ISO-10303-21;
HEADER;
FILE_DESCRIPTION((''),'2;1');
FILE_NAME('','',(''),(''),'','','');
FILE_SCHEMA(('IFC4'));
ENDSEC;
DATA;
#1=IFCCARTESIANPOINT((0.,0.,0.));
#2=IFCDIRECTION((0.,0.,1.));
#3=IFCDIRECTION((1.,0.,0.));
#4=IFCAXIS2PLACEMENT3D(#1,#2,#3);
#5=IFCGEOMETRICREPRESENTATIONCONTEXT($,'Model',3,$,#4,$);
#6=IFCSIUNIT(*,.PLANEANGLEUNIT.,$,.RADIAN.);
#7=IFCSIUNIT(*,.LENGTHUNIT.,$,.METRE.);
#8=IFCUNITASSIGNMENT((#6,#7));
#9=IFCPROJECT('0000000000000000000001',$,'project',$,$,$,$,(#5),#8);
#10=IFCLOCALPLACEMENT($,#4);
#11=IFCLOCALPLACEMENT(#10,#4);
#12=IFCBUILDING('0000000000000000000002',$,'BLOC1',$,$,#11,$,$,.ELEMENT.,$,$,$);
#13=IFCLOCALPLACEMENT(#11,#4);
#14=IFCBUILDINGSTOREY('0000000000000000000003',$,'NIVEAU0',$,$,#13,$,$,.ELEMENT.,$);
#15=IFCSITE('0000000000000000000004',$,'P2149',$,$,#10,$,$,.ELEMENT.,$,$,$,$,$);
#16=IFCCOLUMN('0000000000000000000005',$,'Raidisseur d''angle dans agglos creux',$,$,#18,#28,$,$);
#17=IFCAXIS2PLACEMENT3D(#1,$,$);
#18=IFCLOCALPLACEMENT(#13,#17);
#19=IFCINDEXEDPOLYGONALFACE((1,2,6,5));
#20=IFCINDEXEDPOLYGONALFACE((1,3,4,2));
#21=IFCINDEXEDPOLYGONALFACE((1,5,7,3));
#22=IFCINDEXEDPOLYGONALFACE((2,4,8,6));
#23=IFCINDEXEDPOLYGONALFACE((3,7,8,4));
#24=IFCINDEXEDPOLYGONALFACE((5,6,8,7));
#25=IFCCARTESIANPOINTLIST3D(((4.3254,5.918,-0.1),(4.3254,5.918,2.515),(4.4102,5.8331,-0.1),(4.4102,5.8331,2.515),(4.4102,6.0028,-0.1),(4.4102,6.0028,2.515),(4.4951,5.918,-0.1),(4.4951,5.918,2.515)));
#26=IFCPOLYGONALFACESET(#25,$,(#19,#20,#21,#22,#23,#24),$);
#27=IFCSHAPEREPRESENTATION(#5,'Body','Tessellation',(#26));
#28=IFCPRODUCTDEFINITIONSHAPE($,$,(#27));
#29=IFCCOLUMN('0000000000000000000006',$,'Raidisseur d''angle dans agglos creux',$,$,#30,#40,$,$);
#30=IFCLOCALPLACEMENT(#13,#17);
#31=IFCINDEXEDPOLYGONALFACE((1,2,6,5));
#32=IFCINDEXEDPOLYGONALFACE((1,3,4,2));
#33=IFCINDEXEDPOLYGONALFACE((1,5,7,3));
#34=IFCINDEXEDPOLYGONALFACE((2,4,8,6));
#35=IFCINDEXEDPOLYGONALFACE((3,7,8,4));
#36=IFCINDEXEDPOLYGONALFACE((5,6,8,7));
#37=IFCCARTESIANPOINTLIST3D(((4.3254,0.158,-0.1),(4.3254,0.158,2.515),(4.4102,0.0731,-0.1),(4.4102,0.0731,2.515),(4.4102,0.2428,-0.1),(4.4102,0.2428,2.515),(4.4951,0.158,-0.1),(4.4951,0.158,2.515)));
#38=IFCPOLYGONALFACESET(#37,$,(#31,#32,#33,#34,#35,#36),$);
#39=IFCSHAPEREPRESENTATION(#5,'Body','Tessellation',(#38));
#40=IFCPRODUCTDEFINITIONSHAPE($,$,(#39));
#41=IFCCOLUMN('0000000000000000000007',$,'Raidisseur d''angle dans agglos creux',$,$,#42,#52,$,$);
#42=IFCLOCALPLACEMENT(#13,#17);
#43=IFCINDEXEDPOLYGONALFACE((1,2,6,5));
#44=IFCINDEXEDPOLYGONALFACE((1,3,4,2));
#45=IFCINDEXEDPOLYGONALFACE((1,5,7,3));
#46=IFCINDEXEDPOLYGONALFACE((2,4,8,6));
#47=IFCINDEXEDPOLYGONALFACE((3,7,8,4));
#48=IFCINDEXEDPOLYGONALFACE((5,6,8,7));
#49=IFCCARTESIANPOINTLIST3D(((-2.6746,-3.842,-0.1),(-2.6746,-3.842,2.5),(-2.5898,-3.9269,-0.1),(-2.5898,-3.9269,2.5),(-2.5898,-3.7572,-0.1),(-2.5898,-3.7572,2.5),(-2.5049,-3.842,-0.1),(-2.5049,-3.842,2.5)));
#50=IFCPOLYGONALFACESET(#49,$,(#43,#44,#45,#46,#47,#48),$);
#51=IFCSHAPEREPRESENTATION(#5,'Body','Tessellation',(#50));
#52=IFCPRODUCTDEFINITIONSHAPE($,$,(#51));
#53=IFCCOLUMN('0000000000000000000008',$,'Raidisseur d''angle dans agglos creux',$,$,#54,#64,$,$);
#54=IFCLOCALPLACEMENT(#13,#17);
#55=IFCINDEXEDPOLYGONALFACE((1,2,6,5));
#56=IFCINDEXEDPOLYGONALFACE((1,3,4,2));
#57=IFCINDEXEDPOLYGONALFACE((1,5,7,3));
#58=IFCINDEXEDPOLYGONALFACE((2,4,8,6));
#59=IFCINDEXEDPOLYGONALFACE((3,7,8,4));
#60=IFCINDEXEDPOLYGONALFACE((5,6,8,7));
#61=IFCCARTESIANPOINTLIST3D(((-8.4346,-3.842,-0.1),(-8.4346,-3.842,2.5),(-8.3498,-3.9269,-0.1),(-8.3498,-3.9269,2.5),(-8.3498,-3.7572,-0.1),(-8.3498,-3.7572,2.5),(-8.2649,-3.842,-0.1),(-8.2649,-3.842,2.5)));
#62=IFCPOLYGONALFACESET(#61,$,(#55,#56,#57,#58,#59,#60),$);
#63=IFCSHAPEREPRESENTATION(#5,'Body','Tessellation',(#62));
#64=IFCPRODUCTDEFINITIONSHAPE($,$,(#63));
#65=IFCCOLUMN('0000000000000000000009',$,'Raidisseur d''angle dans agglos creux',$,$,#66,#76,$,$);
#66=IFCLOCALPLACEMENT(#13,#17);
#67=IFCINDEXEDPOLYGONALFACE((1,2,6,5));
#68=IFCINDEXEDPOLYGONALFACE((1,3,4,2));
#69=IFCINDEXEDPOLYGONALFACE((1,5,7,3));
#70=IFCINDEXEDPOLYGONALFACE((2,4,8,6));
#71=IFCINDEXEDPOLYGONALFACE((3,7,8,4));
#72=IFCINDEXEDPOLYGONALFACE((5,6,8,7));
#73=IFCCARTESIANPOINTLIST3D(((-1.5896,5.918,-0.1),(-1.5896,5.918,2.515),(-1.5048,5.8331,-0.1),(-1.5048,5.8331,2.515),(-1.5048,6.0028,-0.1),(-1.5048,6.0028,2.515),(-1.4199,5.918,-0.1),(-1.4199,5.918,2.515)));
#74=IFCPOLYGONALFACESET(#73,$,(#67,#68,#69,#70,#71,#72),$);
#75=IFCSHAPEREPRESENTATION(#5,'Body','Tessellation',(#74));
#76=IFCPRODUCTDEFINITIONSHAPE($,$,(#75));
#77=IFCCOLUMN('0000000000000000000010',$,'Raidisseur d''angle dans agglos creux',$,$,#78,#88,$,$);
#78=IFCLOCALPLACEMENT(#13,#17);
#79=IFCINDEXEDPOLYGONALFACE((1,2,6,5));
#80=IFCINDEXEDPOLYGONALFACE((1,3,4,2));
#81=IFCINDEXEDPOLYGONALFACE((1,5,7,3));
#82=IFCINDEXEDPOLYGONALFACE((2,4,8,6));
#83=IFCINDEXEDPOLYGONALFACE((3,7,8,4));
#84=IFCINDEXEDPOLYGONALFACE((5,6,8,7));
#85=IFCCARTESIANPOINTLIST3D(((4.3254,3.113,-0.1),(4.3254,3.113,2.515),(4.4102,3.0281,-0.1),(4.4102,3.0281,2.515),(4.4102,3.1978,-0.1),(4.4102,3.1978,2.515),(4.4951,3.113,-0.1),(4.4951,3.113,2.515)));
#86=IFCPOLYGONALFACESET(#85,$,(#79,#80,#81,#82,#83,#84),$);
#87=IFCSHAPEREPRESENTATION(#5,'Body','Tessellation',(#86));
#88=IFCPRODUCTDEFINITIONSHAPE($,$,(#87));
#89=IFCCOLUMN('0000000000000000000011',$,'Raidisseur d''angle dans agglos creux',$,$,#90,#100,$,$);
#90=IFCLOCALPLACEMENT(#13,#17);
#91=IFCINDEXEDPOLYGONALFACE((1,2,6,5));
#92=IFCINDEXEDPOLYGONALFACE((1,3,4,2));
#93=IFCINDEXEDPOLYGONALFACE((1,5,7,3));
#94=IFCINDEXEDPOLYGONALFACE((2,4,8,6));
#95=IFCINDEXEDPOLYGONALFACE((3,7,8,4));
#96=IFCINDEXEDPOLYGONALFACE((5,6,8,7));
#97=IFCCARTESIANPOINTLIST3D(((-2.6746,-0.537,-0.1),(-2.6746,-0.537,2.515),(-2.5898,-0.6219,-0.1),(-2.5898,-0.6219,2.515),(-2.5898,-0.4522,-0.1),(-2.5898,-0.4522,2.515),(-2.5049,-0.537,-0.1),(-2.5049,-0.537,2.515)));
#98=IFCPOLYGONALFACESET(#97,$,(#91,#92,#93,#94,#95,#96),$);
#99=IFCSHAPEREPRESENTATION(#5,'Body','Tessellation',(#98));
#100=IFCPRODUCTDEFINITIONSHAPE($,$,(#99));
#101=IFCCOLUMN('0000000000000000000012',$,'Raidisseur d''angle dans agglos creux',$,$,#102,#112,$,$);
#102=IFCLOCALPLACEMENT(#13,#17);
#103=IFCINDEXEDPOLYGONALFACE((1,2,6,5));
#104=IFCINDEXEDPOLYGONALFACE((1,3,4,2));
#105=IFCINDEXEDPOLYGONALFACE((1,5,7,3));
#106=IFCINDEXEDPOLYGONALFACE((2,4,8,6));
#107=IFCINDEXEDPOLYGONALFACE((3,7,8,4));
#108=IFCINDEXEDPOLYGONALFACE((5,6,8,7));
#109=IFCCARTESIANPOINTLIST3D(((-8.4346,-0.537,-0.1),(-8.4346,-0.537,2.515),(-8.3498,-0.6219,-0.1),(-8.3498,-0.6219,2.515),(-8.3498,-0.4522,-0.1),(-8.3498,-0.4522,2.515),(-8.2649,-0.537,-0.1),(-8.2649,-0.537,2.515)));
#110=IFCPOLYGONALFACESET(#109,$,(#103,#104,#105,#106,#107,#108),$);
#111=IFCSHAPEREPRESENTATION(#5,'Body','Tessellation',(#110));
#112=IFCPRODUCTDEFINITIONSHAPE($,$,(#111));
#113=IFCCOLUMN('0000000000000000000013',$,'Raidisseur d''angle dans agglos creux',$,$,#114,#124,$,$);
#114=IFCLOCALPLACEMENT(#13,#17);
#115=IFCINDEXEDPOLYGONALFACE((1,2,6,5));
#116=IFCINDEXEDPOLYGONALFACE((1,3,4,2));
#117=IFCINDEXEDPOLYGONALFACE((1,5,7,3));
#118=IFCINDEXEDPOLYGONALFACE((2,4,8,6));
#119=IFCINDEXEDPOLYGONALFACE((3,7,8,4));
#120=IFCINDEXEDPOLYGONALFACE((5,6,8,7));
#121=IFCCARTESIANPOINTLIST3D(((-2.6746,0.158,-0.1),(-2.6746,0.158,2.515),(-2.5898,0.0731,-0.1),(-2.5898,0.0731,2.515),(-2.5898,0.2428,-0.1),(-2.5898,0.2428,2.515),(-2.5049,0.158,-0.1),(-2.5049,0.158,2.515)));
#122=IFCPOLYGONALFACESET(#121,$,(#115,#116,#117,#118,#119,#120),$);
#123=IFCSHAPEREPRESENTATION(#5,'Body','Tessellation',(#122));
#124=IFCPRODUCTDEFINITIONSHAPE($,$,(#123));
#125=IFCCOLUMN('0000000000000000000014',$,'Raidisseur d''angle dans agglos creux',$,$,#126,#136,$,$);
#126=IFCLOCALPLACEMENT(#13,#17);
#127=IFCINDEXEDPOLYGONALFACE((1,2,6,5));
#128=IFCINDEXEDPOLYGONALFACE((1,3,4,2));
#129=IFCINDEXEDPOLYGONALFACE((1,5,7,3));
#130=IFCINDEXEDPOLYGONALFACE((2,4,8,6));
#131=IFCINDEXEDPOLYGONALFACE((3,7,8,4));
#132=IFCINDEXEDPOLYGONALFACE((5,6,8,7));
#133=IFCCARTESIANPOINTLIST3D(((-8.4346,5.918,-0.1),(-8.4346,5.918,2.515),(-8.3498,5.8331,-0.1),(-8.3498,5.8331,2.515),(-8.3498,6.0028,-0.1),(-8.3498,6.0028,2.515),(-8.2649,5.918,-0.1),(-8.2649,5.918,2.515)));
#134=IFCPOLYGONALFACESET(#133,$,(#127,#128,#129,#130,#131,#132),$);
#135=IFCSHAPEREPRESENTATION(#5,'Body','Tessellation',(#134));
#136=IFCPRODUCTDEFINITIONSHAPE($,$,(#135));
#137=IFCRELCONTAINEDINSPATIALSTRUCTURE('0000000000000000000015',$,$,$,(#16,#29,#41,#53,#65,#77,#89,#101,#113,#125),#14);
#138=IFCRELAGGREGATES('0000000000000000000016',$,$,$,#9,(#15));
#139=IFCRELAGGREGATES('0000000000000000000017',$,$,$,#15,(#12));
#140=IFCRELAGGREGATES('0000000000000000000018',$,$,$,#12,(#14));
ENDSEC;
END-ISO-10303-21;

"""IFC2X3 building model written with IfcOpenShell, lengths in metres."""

from ifc_helpers import new_model, si_unit, point, frame, origin_with_axes, place, context, project, spatial, line_curve, trimmed, segment, composite_curve, outline, extrude, element, save


model = new_model("IFC2X3")

# Units and contexts
model_context = context("Model", 3, world=origin_with_axes())
ifc_project = project(units=[si_unit("PLANEANGLEUNIT", "RADIAN"), si_unit("LENGTHUNIT", "METRE")], contexts=[model_context])

# Site, building, storey
site_placement = place(None, origin_with_axes())
site = spatial("IfcSite", under=ifc_project, at=site_placement, Name="P2149", CompositionType="ELEMENT")
building_placement = place(site_placement, origin_with_axes())
building = spatial("IfcBuilding", under=site, at=building_placement, Name="BLOC1", CompositionType="ELEMENT")
storey_placement = place(building_placement, origin_with_axes())
storey = spatial("IfcBuildingStorey", under=building, at=storey_placement, Name="NIVEAU0", CompositionType="ELEMENT")

# Columns
column_1_placement = place(storey_placement, origin_with_axes())
element("IfcColumn", 1, at=column_1_placement, inside=storey, Name="Raidisseur d'angle dans agglos creux", context=model_context, shape_type="SweptSolid", body=[
    extrude(outline(composite_curve([segment(trimmed(line_curve((0.0, 0.0), (1.0, 0.0), 0.12), [point((0.0, 0.0))], [point((0.12, 0.0))], True, "CARTESIAN"), True, "CONTINUOUS"), segment(trimmed(line_curve((0.12, 0.0), (0.0, 1.0), 0.12), [point((0.12, 0.0))], [point((0.12, 0.12))], True, "CARTESIAN"), True, "CONTINUOUS"), segment(trimmed(line_curve((0.12, 0.12), (-1.0, 0.0), 0.12), [point((0.12, 0.12))], [point((0.0, 0.12))], True, "CARTESIAN"), True, "CONTINUOUS"), segment(trimmed(line_curve((0.0, 0.12), (0.0, -1.0), 0.12), [point((0.0, 0.12))], [point((0.0, 0.0))], True, "CARTESIAN"), True, "CONTINUOUS")], self_intersect=False)), frame((4.3254, 5.918, -0.1), z_axis=(0.0, 0.0, -1.0), x_axis=(0.707107, 0.707107, 0.0)), (0.0, 0.0, -1.0), 2.615),
])
column_2_placement = place(storey_placement, origin_with_axes())
element("IfcColumn", 2, at=column_2_placement, inside=storey, Name="Raidisseur d'angle dans agglos creux", context=model_context, shape_type="SweptSolid", body=[
    extrude(outline(composite_curve([segment(trimmed(line_curve((0.0, 0.0), (1.0, 0.0), 0.12), [point((0.0, 0.0))], [point((0.12, 0.0))], True, "CARTESIAN"), True, "CONTINUOUS"), segment(trimmed(line_curve((0.12, 0.0), (0.0, 1.0), 0.12), [point((0.12, 0.0))], [point((0.12, 0.12))], True, "CARTESIAN"), True, "CONTINUOUS"), segment(trimmed(line_curve((0.12, 0.12), (-1.0, 0.0), 0.12), [point((0.12, 0.12))], [point((0.0, 0.12))], True, "CARTESIAN"), True, "CONTINUOUS"), segment(trimmed(line_curve((0.0, 0.12), (0.0, -1.0), 0.12), [point((0.0, 0.12))], [point((0.0, 0.0))], True, "CARTESIAN"), True, "CONTINUOUS")], self_intersect=False)), frame((4.4102, 0.2428, -0.1), z_axis=(0.0, 0.0, -1.0), x_axis=(0.707107, -0.707107, 0.0)), (0.0, 0.0, -1.0), 2.615),
])
column_3_placement = place(storey_placement, origin_with_axes())
element("IfcColumn", 3, at=column_3_placement, inside=storey, Name="Raidisseur d'angle dans agglos creux", context=model_context, shape_type="SweptSolid", body=[
    extrude(outline(composite_curve([segment(trimmed(line_curve((0.0, 0.0), (1.0, 0.0), 0.12), [point((0.0, 0.0))], [point((0.12, 0.0))], True, "CARTESIAN"), True, "CONTINUOUS"), segment(trimmed(line_curve((0.12, 0.0), (0.0, 1.0), 0.12), [point((0.12, 0.0))], [point((0.12, 0.12))], True, "CARTESIAN"), True, "CONTINUOUS"), segment(trimmed(line_curve((0.12, 0.12), (-1.0, 0.0), 0.12), [point((0.12, 0.12))], [point((0.0, 0.12))], True, "CARTESIAN"), True, "CONTINUOUS"), segment(trimmed(line_curve((0.0, 0.12), (0.0, -1.0), 0.12), [point((0.0, 0.12))], [point((0.0, 0.0))], True, "CARTESIAN"), True, "CONTINUOUS")], self_intersect=False)), frame((-2.5049, -3.842, -0.1), z_axis=(0.0, 0.0, -1.0), x_axis=(-0.707107, -0.707107, 0.0)), (0.0, 0.0, -1.0), 2.6),
])
column_4_placement = place(storey_placement, origin_with_axes())
element("IfcColumn", 4, at=column_4_placement, inside=storey, Name="Raidisseur d'angle dans agglos creux", context=model_context, shape_type="SweptSolid", body=[
    extrude(outline(composite_curve([segment(trimmed(line_curve((0.0, 0.0), (1.0, 0.0), 0.12), [point((0.0, 0.0))], [point((0.12, 0.0))], True, "CARTESIAN"), True, "CONTINUOUS"), segment(trimmed(line_curve((0.12, 0.0), (0.0, 1.0), 0.12), [point((0.12, 0.0))], [point((0.12, 0.12))], True, "CARTESIAN"), True, "CONTINUOUS"), segment(trimmed(line_curve((0.12, 0.12), (-1.0, 0.0), 0.12), [point((0.12, 0.12))], [point((0.0, 0.12))], True, "CARTESIAN"), True, "CONTINUOUS"), segment(trimmed(line_curve((0.0, 0.12), (0.0, -1.0), 0.12), [point((0.0, 0.12))], [point((0.0, 0.0))], True, "CARTESIAN"), True, "CONTINUOUS")], self_intersect=False)), frame((-8.2649, -3.842, -0.1), z_axis=(0.0, 0.0, -1.0), x_axis=(-0.707107, -0.707107, 0.0)), (0.0, 0.0, -1.0), 2.6),
])
column_5_placement = place(storey_placement, origin_with_axes())
element("IfcColumn", 5, at=column_5_placement, inside=storey, Name="Raidisseur d'angle dans agglos creux", context=model_context, shape_type="SweptSolid", body=[
    extrude(outline(composite_curve([segment(trimmed(line_curve((0.0, 0.0), (1.0, 0.0), 0.12), [point((0.0, 0.0))], [point((0.12, 0.0))], True, "CARTESIAN"), True, "CONTINUOUS"), segment(trimmed(line_curve((0.12, 0.0), (0.0, 1.0), 0.12), [point((0.12, 0.0))], [point((0.12, 0.12))], True, "CARTESIAN"), True, "CONTINUOUS"), segment(trimmed(line_curve((0.12, 0.12), (-1.0, 0.0), 0.12), [point((0.12, 0.12))], [point((0.0, 0.12))], True, "CARTESIAN"), True, "CONTINUOUS"), segment(trimmed(line_curve((0.0, 0.12), (0.0, -1.0), 0.12), [point((0.0, 0.12))], [point((0.0, 0.0))], True, "CARTESIAN"), True, "CONTINUOUS")], self_intersect=False)), frame((-1.5896, 5.918, -0.1), z_axis=(0.0, 0.0, -1.0), x_axis=(0.707107, 0.707107, 0.0)), (0.0, 0.0, -1.0), 2.615),
])
column_6_placement = place(storey_placement, origin_with_axes())
element("IfcColumn", 6, at=column_6_placement, inside=storey, Name="Raidisseur d'angle dans agglos creux", context=model_context, shape_type="SweptSolid", body=[
    extrude(outline(composite_curve([segment(trimmed(line_curve((0.0, 0.0), (1.0, 0.0), 0.12), [point((0.0, 0.0))], [point((0.12, 0.0))], True, "CARTESIAN"), True, "CONTINUOUS"), segment(trimmed(line_curve((0.12, 0.0), (0.0, 1.0), 0.12), [point((0.12, 0.0))], [point((0.12, 0.12))], True, "CARTESIAN"), True, "CONTINUOUS"), segment(trimmed(line_curve((0.12, 0.12), (-1.0, 0.0), 0.12), [point((0.12, 0.12))], [point((0.0, 0.12))], True, "CARTESIAN"), True, "CONTINUOUS"), segment(trimmed(line_curve((0.0, 0.12), (0.0, -1.0), 0.12), [point((0.0, 0.12))], [point((0.0, 0.0))], True, "CARTESIAN"), True, "CONTINUOUS")], self_intersect=False)), frame((4.4102, 3.1978, -0.1), z_axis=(0.0, 0.0, -1.0), x_axis=(0.707107, -0.707107, 0.0)), (0.0, 0.0, -1.0), 2.615),
])
column_7_placement = place(storey_placement, origin_with_axes())
element("IfcColumn", 7, at=column_7_placement, inside=storey, Name="Raidisseur d'angle dans agglos creux", context=model_context, shape_type="SweptSolid", body=[
    extrude(outline(composite_curve([segment(trimmed(line_curve((0.0, 0.0), (1.0, 0.0), 0.12), [point((0.0, 0.0))], [point((0.12, 0.0))], True, "CARTESIAN"), True, "CONTINUOUS"), segment(trimmed(line_curve((0.12, 0.0), (0.0, 1.0), 0.12), [point((0.12, 0.0))], [point((0.12, 0.12))], True, "CARTESIAN"), True, "CONTINUOUS"), segment(trimmed(line_curve((0.12, 0.12), (-1.0, 0.0), 0.12), [point((0.12, 0.12))], [point((0.0, 0.12))], True, "CARTESIAN"), True, "CONTINUOUS"), segment(trimmed(line_curve((0.0, 0.12), (0.0, -1.0), 0.12), [point((0.0, 0.12))], [point((0.0, 0.0))], True, "CARTESIAN"), True, "CONTINUOUS")], self_intersect=False)), frame((-2.5898, -0.4522, -0.1), z_axis=(0.0, 0.0, -1.0), x_axis=(0.707107, -0.707107, 0.0)), (0.0, 0.0, -1.0), 2.615),
])
column_8_placement = place(storey_placement, origin_with_axes())
element("IfcColumn", 8, at=column_8_placement, inside=storey, Name="Raidisseur d'angle dans agglos creux", context=model_context, shape_type="SweptSolid", body=[
    extrude(outline(composite_curve([segment(trimmed(line_curve((0.0, 0.0), (1.0, 0.0), 0.12), [point((0.0, 0.0))], [point((0.12, 0.0))], True, "CARTESIAN"), True, "CONTINUOUS"), segment(trimmed(line_curve((0.12, 0.0), (0.0, 1.0), 0.12), [point((0.12, 0.0))], [point((0.12, 0.12))], True, "CARTESIAN"), True, "CONTINUOUS"), segment(trimmed(line_curve((0.12, 0.12), (-1.0, 0.0), 0.12), [point((0.12, 0.12))], [point((0.0, 0.12))], True, "CARTESIAN"), True, "CONTINUOUS"), segment(trimmed(line_curve((0.0, 0.12), (0.0, -1.0), 0.12), [point((0.0, 0.12))], [point((0.0, 0.0))], True, "CARTESIAN"), True, "CONTINUOUS")], self_intersect=False)), frame((-8.3498, -0.6219, -0.1), z_axis=(0.0, 0.0, -1.0), x_axis=(-0.707107, 0.707107, 0.0)), (0.0, 0.0, -1.0), 2.615),
])
column_9_placement = place(storey_placement, origin_with_axes())
element("IfcColumn", 9, at=column_9_placement, inside=storey, Name="Raidisseur d'angle dans agglos creux", context=model_context, shape_type="SweptSolid", body=[
    extrude(outline(composite_curve([segment(trimmed(line_curve((0.0, 0.0), (1.0, 0.0), 0.12), [point((0.0, 0.0))], [point((0.12, 0.0))], True, "CARTESIAN"), True, "CONTINUOUS"), segment(trimmed(line_curve((0.12, 0.0), (0.0, 1.0), 0.12), [point((0.12, 0.0))], [point((0.12, 0.12))], True, "CARTESIAN"), True, "CONTINUOUS"), segment(trimmed(line_curve((0.12, 0.12), (-1.0, 0.0), 0.12), [point((0.12, 0.12))], [point((0.0, 0.12))], True, "CARTESIAN"), True, "CONTINUOUS"), segment(trimmed(line_curve((0.0, 0.12), (0.0, -1.0), 0.12), [point((0.0, 0.12))], [point((0.0, 0.0))], True, "CARTESIAN"), True, "CONTINUOUS")], self_intersect=False)), frame((-2.5049, 0.158, -0.1), z_axis=(0.0, 0.0, -1.0), x_axis=(-0.707107, -0.707107, 0.0)), (0.0, 0.0, -1.0), 2.615),
])
column_10_placement = place(storey_placement, origin_with_axes())
element("IfcColumn", 10, at=column_10_placement, inside=storey, Name="Raidisseur d'angle dans agglos creux", context=model_context, shape_type="SweptSolid", body=[
    extrude(outline(composite_curve([segment(trimmed(line_curve((0.0, 0.0), (1.0, 0.0), 0.12), [point((0.0, 0.0))], [point((0.12, 0.0))], True, "CARTESIAN"), True, "CONTINUOUS"), segment(trimmed(line_curve((0.12, 0.0), (0.0, 1.0), 0.12), [point((0.12, 0.0))], [point((0.12, 0.12))], True, "CARTESIAN"), True, "CONTINUOUS"), segment(trimmed(line_curve((0.12, 0.12), (-1.0, 0.0), 0.12), [point((0.12, 0.12))], [point((0.0, 0.12))], True, "CARTESIAN"), True, "CONTINUOUS"), segment(trimmed(line_curve((0.0, 0.12), (0.0, -1.0), 0.12), [point((0.0, 0.12))], [point((0.0, 0.0))], True, "CARTESIAN"), True, "CONTINUOUS")], self_intersect=False)), frame((-8.4346, 5.918, -0.1), z_axis=(0.0, 0.0, -1.0), x_axis=(0.707107, 0.707107, 0.0)), (0.0, 0.0, -1.0), 2.615),
])

save(model, "model.ifc")
